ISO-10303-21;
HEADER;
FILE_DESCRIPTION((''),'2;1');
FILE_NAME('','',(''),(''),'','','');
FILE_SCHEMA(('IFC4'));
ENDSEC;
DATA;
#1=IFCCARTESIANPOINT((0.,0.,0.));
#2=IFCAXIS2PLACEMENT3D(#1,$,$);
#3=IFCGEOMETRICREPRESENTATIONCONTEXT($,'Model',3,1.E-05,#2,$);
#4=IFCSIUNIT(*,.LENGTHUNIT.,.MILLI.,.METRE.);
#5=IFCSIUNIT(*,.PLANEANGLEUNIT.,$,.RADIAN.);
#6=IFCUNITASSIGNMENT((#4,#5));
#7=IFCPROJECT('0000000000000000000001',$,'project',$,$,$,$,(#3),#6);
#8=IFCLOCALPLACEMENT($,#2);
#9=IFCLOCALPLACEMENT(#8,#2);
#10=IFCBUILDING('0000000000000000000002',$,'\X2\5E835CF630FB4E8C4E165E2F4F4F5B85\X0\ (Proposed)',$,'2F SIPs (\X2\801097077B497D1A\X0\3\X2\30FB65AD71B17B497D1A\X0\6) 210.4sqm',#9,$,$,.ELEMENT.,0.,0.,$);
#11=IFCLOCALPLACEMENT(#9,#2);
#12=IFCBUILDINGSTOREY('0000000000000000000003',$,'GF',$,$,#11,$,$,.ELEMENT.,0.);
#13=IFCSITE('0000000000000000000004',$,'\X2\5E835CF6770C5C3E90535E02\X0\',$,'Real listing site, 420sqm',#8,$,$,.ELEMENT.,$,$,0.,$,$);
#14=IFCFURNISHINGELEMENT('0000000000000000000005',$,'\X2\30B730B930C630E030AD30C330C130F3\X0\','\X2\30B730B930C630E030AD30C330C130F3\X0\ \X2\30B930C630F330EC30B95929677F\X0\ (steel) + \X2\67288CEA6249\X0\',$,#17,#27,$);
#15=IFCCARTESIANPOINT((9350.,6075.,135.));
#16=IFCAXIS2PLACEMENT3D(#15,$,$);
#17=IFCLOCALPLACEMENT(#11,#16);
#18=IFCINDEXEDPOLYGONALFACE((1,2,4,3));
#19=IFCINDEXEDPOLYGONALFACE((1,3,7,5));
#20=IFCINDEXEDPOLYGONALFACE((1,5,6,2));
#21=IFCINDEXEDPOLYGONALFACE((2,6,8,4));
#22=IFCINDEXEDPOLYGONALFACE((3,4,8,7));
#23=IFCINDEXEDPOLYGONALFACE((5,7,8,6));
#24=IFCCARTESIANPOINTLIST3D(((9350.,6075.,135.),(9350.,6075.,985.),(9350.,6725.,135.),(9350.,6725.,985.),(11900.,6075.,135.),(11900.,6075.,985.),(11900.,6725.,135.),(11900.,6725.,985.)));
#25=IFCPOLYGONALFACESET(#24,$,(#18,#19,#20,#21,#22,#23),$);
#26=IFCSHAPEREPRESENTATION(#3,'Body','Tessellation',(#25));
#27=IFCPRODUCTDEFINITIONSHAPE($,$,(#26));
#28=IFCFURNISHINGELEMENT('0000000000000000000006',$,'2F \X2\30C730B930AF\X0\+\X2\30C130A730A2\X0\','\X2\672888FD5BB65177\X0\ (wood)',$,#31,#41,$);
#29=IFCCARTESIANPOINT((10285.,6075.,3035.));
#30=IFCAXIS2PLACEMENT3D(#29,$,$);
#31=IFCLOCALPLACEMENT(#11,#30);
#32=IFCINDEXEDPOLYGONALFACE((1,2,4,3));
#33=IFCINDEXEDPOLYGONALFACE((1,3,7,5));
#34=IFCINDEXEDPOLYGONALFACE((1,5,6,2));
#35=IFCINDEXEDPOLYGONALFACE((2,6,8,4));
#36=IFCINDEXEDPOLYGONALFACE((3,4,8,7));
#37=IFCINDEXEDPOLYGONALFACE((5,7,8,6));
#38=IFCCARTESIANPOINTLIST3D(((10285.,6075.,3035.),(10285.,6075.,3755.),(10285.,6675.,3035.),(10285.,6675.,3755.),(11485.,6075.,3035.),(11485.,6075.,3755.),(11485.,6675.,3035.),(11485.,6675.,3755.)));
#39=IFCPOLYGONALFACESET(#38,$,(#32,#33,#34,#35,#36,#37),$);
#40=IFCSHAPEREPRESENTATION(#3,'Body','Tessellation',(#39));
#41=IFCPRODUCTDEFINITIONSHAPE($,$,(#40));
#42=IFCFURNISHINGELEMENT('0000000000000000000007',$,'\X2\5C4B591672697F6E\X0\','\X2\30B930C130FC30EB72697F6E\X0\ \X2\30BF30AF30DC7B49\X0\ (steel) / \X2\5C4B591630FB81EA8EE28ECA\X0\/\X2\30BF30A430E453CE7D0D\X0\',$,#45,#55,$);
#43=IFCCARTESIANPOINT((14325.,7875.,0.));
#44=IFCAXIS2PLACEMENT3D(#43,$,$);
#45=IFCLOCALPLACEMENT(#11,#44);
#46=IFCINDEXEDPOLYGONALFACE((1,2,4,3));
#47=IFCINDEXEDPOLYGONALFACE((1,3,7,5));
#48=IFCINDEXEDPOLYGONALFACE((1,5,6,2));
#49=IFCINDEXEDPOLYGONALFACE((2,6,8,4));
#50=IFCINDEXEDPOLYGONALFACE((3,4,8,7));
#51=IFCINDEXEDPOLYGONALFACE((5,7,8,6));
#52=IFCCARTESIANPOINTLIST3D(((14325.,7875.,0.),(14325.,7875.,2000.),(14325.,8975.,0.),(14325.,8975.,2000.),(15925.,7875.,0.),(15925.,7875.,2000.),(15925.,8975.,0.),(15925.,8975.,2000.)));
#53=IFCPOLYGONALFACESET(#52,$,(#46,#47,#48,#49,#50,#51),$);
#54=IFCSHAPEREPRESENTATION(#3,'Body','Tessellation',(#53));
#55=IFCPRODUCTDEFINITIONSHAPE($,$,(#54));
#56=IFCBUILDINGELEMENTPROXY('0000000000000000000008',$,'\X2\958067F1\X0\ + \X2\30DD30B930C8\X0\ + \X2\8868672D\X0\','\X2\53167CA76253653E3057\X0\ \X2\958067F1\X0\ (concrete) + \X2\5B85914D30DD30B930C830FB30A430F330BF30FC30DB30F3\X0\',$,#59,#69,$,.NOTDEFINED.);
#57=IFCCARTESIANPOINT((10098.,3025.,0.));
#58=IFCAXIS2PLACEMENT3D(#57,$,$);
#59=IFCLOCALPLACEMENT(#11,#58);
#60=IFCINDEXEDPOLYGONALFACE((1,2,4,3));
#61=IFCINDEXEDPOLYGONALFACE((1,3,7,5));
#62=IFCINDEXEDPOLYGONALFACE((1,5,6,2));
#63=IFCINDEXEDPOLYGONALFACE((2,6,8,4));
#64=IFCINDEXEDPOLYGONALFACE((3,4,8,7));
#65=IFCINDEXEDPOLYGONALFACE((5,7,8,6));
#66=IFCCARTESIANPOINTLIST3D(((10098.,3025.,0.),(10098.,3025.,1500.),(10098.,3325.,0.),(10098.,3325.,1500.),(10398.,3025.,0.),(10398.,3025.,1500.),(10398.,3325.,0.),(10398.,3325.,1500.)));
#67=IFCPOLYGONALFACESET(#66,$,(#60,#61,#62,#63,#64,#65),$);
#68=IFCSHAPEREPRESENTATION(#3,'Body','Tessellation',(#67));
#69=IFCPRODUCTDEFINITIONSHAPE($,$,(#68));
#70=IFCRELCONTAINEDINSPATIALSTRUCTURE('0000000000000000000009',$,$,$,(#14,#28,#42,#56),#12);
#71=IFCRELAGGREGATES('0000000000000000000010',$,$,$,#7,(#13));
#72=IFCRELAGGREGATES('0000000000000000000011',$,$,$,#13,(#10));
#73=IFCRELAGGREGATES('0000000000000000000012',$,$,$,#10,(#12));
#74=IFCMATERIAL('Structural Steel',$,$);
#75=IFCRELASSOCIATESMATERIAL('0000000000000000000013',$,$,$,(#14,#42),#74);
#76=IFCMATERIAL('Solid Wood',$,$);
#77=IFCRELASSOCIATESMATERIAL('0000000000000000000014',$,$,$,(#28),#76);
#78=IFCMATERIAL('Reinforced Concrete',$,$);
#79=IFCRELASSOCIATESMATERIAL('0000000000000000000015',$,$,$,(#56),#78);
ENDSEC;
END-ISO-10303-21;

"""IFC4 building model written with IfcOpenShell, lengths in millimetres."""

from ifc_helpers import new_model, si_unit, frame, frame_2d, origin, place, context, project, spatial, rectangle, extrude, material, element, save


model = new_model("IFC4")

# Units and contexts
model_context = context("Model", 3, precision=1e-05, world=origin())
ifc_project = project(units=[si_unit("LENGTHUNIT", "METRE", prefix="MILLI"), si_unit("PLANEANGLEUNIT", "RADIAN")], contexts=[model_context])

# Site, building, storey
site_placement = place(None, origin())
site = spatial("IfcSite", under=ifc_project, at=site_placement, Name="広島県尾道市", ObjectType="Real listing site, 420sqm", CompositionType="ELEMENT", RefElevation=0.0)
building_placement = place(site_placement, origin())
building = spatial("IfcBuilding", under=site, at=building_placement, Name="広島・二世帯住宅 (Proposed)", ObjectType="2F SIPs (耐震等級3・断熱等級6) 210.4sqm", CompositionType="ELEMENT", ElevationOfRefHeight=0.0, ElevationOfTerrain=0.0)
storey_placement = place(building_placement, origin())
storey = spatial("IfcBuildingStorey", under=building, at=storey_placement, Name="GF", CompositionType="ELEMENT", Elevation=0.0)

# Shared definitions
ifc_material_1 = material(Name="Solid Wood")

# Shared definitions
ifc_material_2 = material(Name="Reinforced Concrete")

# Shared definitions
ifc_material_3 = material(Name="Structural Steel")

# Furnishing elements
furnishing_1_placement = place(storey_placement, frame((9350.0, 6075.0, 135.0)))
element("IfcFurnishingElement", 1, at=furnishing_1_placement, inside=storey, material=ifc_material_3, Name="システムキッチン", Description="システムキッチン ステンレス天板 (steel) + 木質扉", context=model_context, shape_type="SweptSolid", body=[
    extrude(rectangle(XDim=2550.0, YDim=650.0, at=frame_2d((1275.0, 325.0))), frame((9350.0, 6075.0, 135.0)), (0.0, 0.0, 1.0), 850.0),
])
furnishing_2_placement = place(storey_placement, frame((10285.0, 6075.0, 3035.0)))
element("IfcFurnishingElement", 2, at=furnishing_2_placement, inside=storey, material=ifc_material_1, Name="2F デスク+チェア", Description="木製家具 (wood)", context=model_context, shape_type="SweptSolid", body=[
    extrude(rectangle(XDim=1200.0, YDim=600.0, at=frame_2d((600.0, 300.0))), frame((10285.0, 6075.0, 3035.0)), (0.0, 0.0, 1.0), 720.0),
])
furnishing_3_placement = place(storey_placement, frame((14325.0, 7875.0, 0.0)))
element("IfcFurnishingElement", 3, at=furnishing_3_placement, inside=storey, material=ifc_material_3, Name="屋外物置", Description="スチール物置 タクボ等 (steel) / 屋外・自転車/タイヤ収納", context=model_context, shape_type="SweptSolid", body=[
    extrude(rectangle(XDim=1600.0, YDim=1100.0, at=frame_2d((800.0, 550.0))), frame((14325.0, 7875.0, 0.0)), (0.0, 0.0, 1.0), 2000.0),
])

# Building element proxy
proxy_placement = place(storey_placement, frame((10098.0, 3025.0, 0.0)))
element("IfcBuildingElementProxy", 4, at=proxy_placement, inside=storey, material=ifc_material_2, Name="門柱 + ポスト + 表札", Description="化粧打放し 門柱 (concrete) + 宅配ポスト・インターホン", PredefinedType="NOTDEFINED", context=model_context, shape_type="SweptSolid", body=[
    extrude(rectangle(XDim=300.0, YDim=300.0, at=frame_2d((150.0, 150.0))), frame((10098.0, 3025.0, 0.0)), (0.0, 0.0, 1.0), 1500.0),
])

save(model, "model.ifc")
